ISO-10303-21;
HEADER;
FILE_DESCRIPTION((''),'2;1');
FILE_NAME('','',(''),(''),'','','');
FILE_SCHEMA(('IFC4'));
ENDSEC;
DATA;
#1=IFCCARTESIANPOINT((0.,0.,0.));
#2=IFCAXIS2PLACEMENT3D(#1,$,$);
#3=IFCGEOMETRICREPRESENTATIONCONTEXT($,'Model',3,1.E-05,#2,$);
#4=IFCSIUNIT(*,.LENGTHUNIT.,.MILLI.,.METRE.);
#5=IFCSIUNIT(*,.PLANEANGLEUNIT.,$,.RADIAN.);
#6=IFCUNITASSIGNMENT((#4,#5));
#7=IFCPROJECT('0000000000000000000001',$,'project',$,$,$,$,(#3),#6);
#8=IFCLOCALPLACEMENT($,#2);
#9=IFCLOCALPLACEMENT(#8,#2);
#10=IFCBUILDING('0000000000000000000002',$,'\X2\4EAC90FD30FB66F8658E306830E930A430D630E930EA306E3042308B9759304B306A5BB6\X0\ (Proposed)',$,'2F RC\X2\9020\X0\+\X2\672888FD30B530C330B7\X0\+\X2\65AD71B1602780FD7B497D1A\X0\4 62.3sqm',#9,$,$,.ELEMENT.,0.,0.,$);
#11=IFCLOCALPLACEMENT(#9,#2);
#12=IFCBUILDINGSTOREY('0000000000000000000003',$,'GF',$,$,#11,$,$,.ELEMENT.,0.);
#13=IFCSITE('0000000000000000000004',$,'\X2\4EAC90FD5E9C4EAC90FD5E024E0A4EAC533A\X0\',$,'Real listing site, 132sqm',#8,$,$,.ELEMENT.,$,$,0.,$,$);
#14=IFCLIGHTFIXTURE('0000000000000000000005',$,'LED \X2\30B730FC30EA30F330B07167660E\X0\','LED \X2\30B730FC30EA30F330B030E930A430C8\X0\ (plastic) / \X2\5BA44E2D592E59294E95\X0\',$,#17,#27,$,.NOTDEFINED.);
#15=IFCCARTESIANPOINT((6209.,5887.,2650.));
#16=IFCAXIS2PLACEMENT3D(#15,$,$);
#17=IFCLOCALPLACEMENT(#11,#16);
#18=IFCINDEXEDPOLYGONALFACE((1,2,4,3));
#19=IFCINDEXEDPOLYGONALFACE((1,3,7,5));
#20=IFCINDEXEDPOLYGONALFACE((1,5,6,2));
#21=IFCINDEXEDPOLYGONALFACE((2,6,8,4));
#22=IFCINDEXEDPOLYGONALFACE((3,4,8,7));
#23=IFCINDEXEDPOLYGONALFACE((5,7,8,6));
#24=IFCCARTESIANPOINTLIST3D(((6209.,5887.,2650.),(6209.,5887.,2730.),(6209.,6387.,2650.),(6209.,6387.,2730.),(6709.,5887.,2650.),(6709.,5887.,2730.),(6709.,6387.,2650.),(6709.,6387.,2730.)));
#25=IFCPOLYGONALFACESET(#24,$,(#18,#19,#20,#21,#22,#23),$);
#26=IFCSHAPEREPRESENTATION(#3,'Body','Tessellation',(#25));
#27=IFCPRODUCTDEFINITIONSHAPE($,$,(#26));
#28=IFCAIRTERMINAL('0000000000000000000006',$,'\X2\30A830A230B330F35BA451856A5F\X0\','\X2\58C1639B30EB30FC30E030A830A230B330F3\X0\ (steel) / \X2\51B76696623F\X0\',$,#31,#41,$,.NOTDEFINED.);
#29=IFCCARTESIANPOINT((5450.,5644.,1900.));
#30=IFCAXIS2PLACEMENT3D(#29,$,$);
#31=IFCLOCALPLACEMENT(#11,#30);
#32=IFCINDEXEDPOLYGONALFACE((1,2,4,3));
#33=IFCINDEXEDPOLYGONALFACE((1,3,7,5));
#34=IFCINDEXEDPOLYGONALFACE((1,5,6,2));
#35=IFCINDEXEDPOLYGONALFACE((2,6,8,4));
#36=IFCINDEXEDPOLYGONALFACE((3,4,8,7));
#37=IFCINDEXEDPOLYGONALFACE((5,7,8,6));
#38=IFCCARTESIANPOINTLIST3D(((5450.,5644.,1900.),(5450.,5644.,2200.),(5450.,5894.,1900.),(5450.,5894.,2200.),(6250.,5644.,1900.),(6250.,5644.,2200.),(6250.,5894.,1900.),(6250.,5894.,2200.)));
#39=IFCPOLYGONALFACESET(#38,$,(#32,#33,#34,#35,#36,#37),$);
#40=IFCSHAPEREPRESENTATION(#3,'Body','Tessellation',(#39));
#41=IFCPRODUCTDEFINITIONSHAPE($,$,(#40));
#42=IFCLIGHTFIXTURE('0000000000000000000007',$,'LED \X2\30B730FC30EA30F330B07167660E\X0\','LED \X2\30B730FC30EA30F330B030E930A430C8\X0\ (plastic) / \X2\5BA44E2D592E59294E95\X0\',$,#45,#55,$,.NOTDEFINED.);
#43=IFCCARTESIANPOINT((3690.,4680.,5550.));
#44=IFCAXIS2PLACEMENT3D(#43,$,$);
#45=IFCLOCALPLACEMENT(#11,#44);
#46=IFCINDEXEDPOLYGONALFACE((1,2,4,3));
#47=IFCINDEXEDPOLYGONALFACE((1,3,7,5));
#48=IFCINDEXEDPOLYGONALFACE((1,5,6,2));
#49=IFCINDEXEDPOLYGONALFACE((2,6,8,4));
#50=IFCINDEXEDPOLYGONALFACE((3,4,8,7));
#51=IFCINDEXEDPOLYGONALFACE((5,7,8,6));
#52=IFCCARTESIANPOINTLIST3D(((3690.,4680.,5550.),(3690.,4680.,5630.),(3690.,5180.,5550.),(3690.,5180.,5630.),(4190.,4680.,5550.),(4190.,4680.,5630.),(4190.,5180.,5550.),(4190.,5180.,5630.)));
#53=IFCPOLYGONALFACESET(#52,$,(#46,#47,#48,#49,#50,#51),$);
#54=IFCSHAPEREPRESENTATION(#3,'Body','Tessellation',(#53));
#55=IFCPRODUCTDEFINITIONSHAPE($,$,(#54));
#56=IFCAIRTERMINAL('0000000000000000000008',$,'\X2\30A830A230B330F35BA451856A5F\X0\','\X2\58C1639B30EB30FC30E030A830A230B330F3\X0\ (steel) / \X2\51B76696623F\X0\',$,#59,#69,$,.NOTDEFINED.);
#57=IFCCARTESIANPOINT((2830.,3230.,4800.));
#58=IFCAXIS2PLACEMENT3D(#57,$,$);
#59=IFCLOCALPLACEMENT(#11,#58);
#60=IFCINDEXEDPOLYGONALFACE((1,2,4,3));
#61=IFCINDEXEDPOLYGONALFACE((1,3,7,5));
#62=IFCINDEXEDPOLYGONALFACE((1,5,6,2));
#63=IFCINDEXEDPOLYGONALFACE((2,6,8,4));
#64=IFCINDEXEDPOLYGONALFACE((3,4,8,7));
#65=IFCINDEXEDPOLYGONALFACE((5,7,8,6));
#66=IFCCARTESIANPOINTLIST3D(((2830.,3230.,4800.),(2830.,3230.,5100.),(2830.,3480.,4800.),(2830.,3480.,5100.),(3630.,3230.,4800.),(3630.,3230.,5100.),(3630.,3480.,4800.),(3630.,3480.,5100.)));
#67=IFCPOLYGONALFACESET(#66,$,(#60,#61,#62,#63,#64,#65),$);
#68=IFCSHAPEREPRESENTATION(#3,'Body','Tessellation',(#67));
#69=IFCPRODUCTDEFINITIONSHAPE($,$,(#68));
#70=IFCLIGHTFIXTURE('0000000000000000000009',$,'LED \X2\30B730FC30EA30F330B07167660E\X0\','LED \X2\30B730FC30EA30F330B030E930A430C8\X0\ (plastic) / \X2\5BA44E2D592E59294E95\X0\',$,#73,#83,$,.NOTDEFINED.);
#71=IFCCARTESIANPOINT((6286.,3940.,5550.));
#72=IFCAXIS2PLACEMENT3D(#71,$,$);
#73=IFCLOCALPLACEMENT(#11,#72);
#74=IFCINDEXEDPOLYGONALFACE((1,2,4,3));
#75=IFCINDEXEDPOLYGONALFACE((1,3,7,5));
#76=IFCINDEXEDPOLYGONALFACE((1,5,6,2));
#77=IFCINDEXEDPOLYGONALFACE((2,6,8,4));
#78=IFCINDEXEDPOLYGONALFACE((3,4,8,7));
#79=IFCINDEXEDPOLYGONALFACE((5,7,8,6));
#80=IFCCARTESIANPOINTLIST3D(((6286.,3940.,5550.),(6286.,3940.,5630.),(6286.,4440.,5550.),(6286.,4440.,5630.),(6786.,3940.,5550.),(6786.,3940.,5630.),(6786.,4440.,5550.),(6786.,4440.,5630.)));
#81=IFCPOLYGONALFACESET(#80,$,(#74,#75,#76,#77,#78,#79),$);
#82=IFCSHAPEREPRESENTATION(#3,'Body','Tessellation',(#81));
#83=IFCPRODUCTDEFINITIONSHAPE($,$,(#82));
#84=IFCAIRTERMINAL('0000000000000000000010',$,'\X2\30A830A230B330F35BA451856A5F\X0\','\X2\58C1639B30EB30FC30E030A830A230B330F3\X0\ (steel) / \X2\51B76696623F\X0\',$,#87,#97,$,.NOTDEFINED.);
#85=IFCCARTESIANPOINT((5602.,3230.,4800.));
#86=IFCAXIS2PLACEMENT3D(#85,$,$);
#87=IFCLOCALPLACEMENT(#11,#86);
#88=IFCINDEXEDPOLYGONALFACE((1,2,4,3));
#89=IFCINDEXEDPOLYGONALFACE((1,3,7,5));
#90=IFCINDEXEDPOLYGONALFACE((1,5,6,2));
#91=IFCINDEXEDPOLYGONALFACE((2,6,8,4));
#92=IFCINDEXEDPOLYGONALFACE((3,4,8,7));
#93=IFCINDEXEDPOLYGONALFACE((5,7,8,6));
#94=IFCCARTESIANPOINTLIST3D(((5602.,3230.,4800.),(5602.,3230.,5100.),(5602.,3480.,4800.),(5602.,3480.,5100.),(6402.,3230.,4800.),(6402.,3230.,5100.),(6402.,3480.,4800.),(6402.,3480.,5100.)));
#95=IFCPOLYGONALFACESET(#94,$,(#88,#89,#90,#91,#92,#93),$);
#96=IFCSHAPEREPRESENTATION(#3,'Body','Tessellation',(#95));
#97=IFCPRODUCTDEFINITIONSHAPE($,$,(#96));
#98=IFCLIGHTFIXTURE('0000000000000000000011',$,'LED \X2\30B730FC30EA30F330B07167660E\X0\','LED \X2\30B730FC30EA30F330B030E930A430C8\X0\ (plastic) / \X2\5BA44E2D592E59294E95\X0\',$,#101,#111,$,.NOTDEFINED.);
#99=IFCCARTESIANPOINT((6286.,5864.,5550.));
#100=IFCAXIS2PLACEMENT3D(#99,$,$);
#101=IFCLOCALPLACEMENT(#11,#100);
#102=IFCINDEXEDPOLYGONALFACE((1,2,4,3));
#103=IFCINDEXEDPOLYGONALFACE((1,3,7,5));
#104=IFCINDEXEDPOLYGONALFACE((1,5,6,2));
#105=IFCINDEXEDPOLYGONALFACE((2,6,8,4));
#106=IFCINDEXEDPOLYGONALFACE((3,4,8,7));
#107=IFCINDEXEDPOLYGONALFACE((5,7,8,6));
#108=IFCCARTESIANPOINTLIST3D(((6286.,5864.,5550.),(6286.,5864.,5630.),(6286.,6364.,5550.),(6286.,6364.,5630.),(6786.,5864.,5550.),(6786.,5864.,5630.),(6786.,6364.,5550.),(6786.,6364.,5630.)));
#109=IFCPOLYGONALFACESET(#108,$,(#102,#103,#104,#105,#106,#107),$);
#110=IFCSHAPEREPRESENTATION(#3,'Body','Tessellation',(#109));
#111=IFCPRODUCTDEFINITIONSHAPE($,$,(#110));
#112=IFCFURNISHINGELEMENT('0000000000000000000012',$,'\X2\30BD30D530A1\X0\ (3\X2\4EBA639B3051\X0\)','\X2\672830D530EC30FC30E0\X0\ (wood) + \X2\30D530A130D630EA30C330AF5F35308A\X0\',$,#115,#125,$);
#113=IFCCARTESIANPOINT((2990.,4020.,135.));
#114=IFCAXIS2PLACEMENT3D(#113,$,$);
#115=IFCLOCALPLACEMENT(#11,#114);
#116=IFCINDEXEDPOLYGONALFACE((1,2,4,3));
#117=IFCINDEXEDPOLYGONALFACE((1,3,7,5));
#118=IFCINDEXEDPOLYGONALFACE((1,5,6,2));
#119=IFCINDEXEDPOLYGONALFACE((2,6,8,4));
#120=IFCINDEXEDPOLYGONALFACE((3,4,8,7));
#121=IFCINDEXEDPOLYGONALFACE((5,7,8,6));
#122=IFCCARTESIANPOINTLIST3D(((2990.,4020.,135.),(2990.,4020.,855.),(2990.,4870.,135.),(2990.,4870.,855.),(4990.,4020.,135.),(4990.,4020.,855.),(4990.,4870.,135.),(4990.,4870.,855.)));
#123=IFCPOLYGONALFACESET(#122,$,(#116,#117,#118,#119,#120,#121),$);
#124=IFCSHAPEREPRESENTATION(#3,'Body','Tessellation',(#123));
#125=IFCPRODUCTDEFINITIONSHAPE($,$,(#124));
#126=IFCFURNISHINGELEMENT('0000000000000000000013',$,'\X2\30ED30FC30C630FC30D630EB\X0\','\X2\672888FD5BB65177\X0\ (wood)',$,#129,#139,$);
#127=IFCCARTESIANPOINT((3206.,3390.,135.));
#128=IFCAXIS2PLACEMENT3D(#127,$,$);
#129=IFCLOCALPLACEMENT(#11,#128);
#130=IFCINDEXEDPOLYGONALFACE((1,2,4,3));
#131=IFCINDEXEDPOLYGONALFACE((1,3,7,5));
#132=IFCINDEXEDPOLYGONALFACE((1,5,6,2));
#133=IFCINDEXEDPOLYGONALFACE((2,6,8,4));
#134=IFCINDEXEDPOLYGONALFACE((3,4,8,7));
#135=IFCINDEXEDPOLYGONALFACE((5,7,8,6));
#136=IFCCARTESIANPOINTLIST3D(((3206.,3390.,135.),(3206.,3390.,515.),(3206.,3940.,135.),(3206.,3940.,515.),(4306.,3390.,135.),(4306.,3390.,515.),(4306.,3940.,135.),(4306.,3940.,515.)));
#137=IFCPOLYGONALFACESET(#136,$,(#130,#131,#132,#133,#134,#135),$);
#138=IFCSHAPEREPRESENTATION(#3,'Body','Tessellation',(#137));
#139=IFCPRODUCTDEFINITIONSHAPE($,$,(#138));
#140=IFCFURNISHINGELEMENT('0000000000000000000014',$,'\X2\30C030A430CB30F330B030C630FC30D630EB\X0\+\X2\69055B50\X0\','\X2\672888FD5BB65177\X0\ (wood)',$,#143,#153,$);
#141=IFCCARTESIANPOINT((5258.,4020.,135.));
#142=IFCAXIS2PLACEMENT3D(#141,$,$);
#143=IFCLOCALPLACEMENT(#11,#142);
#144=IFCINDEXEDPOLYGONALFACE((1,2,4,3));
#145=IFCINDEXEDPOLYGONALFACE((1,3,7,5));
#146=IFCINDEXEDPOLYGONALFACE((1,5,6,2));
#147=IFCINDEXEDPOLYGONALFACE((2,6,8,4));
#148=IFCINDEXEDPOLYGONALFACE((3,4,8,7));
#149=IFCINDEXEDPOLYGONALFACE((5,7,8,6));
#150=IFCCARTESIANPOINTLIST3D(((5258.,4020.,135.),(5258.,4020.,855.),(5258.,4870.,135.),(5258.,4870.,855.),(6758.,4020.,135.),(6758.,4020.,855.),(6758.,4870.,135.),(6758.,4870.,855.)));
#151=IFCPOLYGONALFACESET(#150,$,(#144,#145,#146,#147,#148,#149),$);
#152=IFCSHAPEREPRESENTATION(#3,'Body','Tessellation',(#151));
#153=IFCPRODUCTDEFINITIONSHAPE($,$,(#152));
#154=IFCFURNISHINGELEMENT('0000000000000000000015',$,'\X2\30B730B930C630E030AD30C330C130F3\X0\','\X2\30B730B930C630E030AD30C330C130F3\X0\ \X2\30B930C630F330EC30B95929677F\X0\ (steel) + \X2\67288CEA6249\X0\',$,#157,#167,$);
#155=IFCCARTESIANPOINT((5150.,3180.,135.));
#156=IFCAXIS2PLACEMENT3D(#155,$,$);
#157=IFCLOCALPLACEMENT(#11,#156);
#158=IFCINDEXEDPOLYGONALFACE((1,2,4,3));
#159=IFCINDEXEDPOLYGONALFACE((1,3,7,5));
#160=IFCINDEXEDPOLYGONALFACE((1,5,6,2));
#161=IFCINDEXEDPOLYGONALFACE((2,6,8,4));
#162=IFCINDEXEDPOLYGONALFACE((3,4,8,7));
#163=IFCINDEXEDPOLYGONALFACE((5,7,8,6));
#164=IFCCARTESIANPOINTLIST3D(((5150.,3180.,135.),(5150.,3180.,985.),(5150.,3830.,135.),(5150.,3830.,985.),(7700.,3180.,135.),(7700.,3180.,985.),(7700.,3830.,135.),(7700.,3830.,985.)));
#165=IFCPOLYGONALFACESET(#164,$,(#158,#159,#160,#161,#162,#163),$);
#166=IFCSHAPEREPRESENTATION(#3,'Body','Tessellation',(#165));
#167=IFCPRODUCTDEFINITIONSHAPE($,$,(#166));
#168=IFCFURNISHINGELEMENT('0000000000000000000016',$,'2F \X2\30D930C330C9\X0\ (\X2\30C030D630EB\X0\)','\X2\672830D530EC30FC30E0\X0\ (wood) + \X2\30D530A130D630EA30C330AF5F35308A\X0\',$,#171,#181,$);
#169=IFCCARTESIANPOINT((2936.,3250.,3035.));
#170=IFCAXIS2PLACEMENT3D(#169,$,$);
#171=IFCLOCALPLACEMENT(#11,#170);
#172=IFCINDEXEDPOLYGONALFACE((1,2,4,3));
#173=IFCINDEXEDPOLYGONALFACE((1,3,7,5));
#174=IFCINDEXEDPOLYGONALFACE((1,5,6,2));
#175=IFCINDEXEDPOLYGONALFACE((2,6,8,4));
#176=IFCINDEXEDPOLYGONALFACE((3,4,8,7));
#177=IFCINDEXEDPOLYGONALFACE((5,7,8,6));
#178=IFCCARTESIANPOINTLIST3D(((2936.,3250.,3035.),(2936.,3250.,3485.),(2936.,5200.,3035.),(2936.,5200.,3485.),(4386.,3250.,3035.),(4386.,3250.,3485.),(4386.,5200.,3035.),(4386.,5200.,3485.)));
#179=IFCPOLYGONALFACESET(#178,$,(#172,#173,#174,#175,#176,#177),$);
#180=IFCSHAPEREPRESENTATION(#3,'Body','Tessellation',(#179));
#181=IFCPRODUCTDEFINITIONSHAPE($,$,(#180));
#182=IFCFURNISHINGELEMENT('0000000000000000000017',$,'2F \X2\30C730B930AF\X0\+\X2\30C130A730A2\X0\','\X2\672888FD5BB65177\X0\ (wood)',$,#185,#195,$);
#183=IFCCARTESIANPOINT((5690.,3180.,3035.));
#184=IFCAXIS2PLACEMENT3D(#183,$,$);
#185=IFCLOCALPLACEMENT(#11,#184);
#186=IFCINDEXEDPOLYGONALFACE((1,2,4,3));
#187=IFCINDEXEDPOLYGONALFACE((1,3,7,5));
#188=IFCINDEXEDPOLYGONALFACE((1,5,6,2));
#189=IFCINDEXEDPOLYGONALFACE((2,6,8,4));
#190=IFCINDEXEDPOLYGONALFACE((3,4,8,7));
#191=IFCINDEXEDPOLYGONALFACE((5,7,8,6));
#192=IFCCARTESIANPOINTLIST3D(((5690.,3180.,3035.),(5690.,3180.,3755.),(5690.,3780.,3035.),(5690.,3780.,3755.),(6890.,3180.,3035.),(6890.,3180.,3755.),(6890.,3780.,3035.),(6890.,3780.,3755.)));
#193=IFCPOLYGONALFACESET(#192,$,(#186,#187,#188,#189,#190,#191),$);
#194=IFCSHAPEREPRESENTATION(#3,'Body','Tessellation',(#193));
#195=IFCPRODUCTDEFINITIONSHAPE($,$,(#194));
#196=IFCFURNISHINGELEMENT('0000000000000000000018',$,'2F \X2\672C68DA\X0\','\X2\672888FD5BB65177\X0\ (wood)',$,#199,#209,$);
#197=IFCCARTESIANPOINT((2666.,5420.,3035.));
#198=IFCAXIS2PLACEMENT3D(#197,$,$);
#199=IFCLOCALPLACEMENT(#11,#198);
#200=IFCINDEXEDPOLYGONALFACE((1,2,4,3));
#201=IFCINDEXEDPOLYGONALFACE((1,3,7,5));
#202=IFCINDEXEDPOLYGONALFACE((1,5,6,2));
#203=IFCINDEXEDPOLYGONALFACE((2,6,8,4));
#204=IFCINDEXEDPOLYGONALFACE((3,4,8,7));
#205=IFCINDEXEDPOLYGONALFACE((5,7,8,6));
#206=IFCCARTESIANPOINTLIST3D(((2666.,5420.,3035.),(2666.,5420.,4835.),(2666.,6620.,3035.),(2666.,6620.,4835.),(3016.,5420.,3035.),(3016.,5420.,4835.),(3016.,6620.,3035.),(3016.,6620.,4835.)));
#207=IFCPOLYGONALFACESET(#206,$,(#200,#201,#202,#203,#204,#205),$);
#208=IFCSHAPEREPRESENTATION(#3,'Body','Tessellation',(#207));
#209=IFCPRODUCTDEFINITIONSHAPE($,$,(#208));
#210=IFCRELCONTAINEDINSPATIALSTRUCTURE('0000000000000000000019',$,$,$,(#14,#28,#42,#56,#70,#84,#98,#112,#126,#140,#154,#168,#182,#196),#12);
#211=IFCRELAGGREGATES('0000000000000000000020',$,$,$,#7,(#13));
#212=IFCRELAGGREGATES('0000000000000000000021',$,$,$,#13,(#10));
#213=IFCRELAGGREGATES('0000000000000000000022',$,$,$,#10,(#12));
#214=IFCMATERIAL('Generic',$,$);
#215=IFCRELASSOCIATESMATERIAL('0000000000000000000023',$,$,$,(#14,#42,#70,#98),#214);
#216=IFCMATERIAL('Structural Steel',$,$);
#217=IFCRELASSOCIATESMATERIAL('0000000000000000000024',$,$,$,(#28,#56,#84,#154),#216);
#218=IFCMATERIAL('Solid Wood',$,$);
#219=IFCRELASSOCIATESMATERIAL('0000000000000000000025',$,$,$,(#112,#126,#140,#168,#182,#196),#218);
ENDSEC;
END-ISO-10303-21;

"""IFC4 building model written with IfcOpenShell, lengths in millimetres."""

from ifc_helpers import new_model, si_unit, frame, frame_2d, origin, place, context, project, spatial, rectangle, extrude, material, element, save


model = new_model("IFC4")

# Units and contexts
model_context = context("Model", 3, precision=1e-05, world=origin())
ifc_project = project(units=[si_unit("LENGTHUNIT", "METRE", prefix="MILLI"), si_unit("PLANEANGLEUNIT", "RADIAN")], contexts=[model_context])

# Site, building, storey
site_placement = place(None, origin())
site = spatial("IfcSite", under=ifc_project, at=site_placement, Name="京都府京都市上京区", ObjectType="Real listing site, 132sqm", CompositionType="ELEMENT", RefElevation=0.0)
building_placement = place(site_placement, origin())
building = spatial("IfcBuilding", under=site, at=building_placement, Name="京都・書斎とライブラリのある静かな家 (Proposed)", ObjectType="2F RC造+木製サッシ+断熱性能等級4 62.3sqm", CompositionType="ELEMENT", ElevationOfRefHeight=0.0, ElevationOfTerrain=0.0)
storey_placement = place(building_placement, origin())
storey = spatial("IfcBuildingStorey", under=building, at=storey_placement, Name="GF", CompositionType="ELEMENT", Elevation=0.0)

# Shared definitions
ifc_material_1 = material(Name="Solid Wood")

# Shared definitions
ifc_material_2 = material(Name="Structural Steel")

# Shared definitions
ifc_material_3 = material(Name="Generic")

# Light fixture
light_fixture_1_placement = place(storey_placement, frame((6209.0, 5887.0, 2650.0)))
element("IfcLightFixture", 1, at=light_fixture_1_placement, inside=storey, material=ifc_material_3, Name="LED シーリング照明", Description="LED シーリングライト (plastic) / 室中央天井", PredefinedType="NOTDEFINED", context=model_context, shape_type="SweptSolid", body=[
    extrude(rectangle(XDim=500.0, YDim=500.0, at=frame_2d((250.0, 250.0))), frame((6209.0, 5887.0, 2650.0)), (0.0, 0.0, 1.0), 80.0),
])

# Air terminal
air_terminal_1_placement = place(storey_placement, frame((5450.0, 5644.0, 1900.0)))
element("IfcAirTerminal", 2, at=air_terminal_1_placement, inside=storey, material=ifc_material_2, Name="エアコン室内機", Description="壁掛ルームエアコン (steel) / 冷暖房", PredefinedType="NOTDEFINED", context=model_context, shape_type="SweptSolid", body=[
    extrude(rectangle(XDim=800.0, YDim=250.0, at=frame_2d((400.0, 125.0))), frame((5450.0, 5644.0, 1900.0)), (0.0, 0.0, 1.0), 300.0),
])

# Light fixture
light_fixture_2_placement = place(storey_placement, frame((3690.0, 4680.0, 5550.0)))
element("IfcLightFixture", 3, at=light_fixture_2_placement, inside=storey, material=ifc_material_3, Name="LED シーリング照明", Description="LED シーリングライト (plastic) / 室中央天井", PredefinedType="NOTDEFINED", context=model_context, shape_type="SweptSolid", body=[
    extrude(rectangle(XDim=500.0, YDim=500.0, at=frame_2d((250.0, 250.0))), frame((3690.0, 4680.0, 5550.0)), (0.0, 0.0, 1.0), 80.0),
])

# Air terminal
air_terminal_2_placement = place(storey_placement, frame((2830.0, 3230.0, 4800.0)))
element("IfcAirTerminal", 4, at=air_terminal_2_placement, inside=storey, material=ifc_material_2, Name="エアコン室内機", Description="壁掛ルームエアコン (steel) / 冷暖房", PredefinedType="NOTDEFINED", context=model_context, shape_type="SweptSolid", body=[
    extrude(rectangle(XDim=800.0, YDim=250.0, at=frame_2d((400.0, 125.0))), frame((2830.0, 3230.0, 4800.0)), (0.0, 0.0, 1.0), 300.0),
])

# Light fixture
light_fixture_3_placement = place(storey_placement, frame((6286.0, 3940.0, 5550.0)))
element("IfcLightFixture", 5, at=light_fixture_3_placement, inside=storey, material=ifc_material_3, Name="LED シーリング照明", Description="LED シーリングライト (plastic) / 室中央天井", PredefinedType="NOTDEFINED", context=model_context, shape_type="SweptSolid", body=[
    extrude(rectangle(XDim=500.0, YDim=500.0, at=frame_2d((250.0, 250.0))), frame((6286.0, 3940.0, 5550.0)), (0.0, 0.0, 1.0), 80.0),
])

# Air terminal
air_terminal_3_placement = place(storey_placement, frame((5602.0, 3230.0, 4800.0)))
element("IfcAirTerminal", 6, at=air_terminal_3_placement, inside=storey, material=ifc_material_2, Name="エアコン室内機", Description="壁掛ルームエアコン (steel) / 冷暖房", PredefinedType="NOTDEFINED", context=model_context, shape_type="SweptSolid", body=[
    extrude(rectangle(XDim=800.0, YDim=250.0, at=frame_2d((400.0, 125.0))), frame((5602.0, 3230.0, 4800.0)), (0.0, 0.0, 1.0), 300.0),
])

# Light fixture
light_fixture_4_placement = place(storey_placement, frame((6286.0, 5864.0, 5550.0)))
element("IfcLightFixture", 7, at=light_fixture_4_placement, inside=storey, material=ifc_material_3, Name="LED シーリング照明", Description="LED シーリングライト (plastic) / 室中央天井", PredefinedType="NOTDEFINED", context=model_context, shape_type="SweptSolid", body=[
    extrude(rectangle(XDim=500.0, YDim=500.0, at=frame_2d((250.0, 250.0))), frame((6286.0, 5864.0, 5550.0)), (0.0, 0.0, 1.0), 80.0),
])

# Furnishing elements
furnishing_1_placement = place(storey_placement, frame((2990.0, 4020.0, 135.0)))
element("IfcFurnishingElement", 8, at=furnishing_1_placement, inside=storey, material=ifc_material_1, Name="ソファ (3人掛け)", Description="木フレーム (wood) + ファブリック張り", context=model_context, shape_type="SweptSolid", body=[
    extrude(rectangle(XDim=2000.0, YDim=850.0, at=frame_2d((1000.0, 425.0))), frame((2990.0, 4020.0, 135.0)), (0.0, 0.0, 1.0), 720.0),
])
furnishing_2_placement = place(storey_placement, frame((3206.0, 3390.0, 135.0)))
element("IfcFurnishingElement", 9, at=furnishing_2_placement, inside=storey, material=ifc_material_1, Name="ローテーブル", Description="木製家具 (wood)", context=model_context, shape_type="SweptSolid", body=[
    extrude(rectangle(XDim=1100.0, YDim=550.0, at=frame_2d((550.0, 275.0))), frame((3206.0, 3390.0, 135.0)), (0.0, 0.0, 1.0), 380.0),
])
furnishing_3_placement = place(storey_placement, frame((5258.0, 4020.0, 135.0)))
element("IfcFurnishingElement", 10, at=furnishing_3_placement, inside=storey, material=ifc_material_1, Name="ダイニングテーブル+椅子", Description="木製家具 (wood)", context=model_context, shape_type="SweptSolid", body=[
    extrude(rectangle(XDim=1500.0, YDim=850.0, at=frame_2d((750.0, 425.0))), frame((5258.0, 4020.0, 135.0)), (0.0, 0.0, 1.0), 720.0),
])
furnishing_4_placement = place(storey_placement, frame((5150.0, 3180.0, 135.0)))
element("IfcFurnishingElement", 11, at=furnishing_4_placement, inside=storey, material=ifc_material_2, Name="システムキッチン", Description="システムキッチン ステンレス天板 (steel) + 木質扉", context=model_context, shape_type="SweptSolid", body=[
    extrude(rectangle(XDim=2550.0, YDim=650.0, at=frame_2d((1275.0, 325.0))), frame((5150.0, 3180.0, 135.0)), (0.0, 0.0, 1.0), 850.0),
])
furnishing_5_placement = place(storey_placement, frame((2936.0, 3250.0, 3035.0)))
element("IfcFurnishingElement", 12, at=furnishing_5_placement, inside=storey, material=ifc_material_1, Name="2F ベッド (ダブル)", Description="木フレーム (wood) + ファブリック張り", context=model_context, shape_type="SweptSolid", body=[
    extrude(rectangle(XDim=1450.0, YDim=1950.0, at=frame_2d((725.0, 975.0))), frame((2936.0, 3250.0, 3035.0)), (0.0, 0.0, 1.0), 450.0),
])
furnishing_6_placement = place(storey_placement, frame((5690.0, 3180.0, 3035.0)))
element("IfcFurnishingElement", 13, at=furnishing_6_placement, inside=storey, material=ifc_material_1, Name="2F デスク+チェア", Description="木製家具 (wood)", context=model_context, shape_type="SweptSolid", body=[
    extrude(rectangle(XDim=1200.0, YDim=600.0, at=frame_2d((600.0, 300.0))), frame((5690.0, 3180.0, 3035.0)), (0.0, 0.0, 1.0), 720.0),
])
furnishing_7_placement = place(storey_placement, frame((2666.0, 5420.0, 3035.0)))
element("IfcFurnishingElement", 14, at=furnishing_7_placement, inside=storey, material=ifc_material_1, Name="2F 本棚", Description="木製家具 (wood)", context=model_context, shape_type="SweptSolid", body=[
    extrude(rectangle(XDim=350.0, YDim=1200.0, at=frame_2d((175.0, 600.0))), frame((2666.0, 5420.0, 3035.0)), (0.0, 0.0, 1.0), 1800.0),
])

save(model, "model.ifc")
